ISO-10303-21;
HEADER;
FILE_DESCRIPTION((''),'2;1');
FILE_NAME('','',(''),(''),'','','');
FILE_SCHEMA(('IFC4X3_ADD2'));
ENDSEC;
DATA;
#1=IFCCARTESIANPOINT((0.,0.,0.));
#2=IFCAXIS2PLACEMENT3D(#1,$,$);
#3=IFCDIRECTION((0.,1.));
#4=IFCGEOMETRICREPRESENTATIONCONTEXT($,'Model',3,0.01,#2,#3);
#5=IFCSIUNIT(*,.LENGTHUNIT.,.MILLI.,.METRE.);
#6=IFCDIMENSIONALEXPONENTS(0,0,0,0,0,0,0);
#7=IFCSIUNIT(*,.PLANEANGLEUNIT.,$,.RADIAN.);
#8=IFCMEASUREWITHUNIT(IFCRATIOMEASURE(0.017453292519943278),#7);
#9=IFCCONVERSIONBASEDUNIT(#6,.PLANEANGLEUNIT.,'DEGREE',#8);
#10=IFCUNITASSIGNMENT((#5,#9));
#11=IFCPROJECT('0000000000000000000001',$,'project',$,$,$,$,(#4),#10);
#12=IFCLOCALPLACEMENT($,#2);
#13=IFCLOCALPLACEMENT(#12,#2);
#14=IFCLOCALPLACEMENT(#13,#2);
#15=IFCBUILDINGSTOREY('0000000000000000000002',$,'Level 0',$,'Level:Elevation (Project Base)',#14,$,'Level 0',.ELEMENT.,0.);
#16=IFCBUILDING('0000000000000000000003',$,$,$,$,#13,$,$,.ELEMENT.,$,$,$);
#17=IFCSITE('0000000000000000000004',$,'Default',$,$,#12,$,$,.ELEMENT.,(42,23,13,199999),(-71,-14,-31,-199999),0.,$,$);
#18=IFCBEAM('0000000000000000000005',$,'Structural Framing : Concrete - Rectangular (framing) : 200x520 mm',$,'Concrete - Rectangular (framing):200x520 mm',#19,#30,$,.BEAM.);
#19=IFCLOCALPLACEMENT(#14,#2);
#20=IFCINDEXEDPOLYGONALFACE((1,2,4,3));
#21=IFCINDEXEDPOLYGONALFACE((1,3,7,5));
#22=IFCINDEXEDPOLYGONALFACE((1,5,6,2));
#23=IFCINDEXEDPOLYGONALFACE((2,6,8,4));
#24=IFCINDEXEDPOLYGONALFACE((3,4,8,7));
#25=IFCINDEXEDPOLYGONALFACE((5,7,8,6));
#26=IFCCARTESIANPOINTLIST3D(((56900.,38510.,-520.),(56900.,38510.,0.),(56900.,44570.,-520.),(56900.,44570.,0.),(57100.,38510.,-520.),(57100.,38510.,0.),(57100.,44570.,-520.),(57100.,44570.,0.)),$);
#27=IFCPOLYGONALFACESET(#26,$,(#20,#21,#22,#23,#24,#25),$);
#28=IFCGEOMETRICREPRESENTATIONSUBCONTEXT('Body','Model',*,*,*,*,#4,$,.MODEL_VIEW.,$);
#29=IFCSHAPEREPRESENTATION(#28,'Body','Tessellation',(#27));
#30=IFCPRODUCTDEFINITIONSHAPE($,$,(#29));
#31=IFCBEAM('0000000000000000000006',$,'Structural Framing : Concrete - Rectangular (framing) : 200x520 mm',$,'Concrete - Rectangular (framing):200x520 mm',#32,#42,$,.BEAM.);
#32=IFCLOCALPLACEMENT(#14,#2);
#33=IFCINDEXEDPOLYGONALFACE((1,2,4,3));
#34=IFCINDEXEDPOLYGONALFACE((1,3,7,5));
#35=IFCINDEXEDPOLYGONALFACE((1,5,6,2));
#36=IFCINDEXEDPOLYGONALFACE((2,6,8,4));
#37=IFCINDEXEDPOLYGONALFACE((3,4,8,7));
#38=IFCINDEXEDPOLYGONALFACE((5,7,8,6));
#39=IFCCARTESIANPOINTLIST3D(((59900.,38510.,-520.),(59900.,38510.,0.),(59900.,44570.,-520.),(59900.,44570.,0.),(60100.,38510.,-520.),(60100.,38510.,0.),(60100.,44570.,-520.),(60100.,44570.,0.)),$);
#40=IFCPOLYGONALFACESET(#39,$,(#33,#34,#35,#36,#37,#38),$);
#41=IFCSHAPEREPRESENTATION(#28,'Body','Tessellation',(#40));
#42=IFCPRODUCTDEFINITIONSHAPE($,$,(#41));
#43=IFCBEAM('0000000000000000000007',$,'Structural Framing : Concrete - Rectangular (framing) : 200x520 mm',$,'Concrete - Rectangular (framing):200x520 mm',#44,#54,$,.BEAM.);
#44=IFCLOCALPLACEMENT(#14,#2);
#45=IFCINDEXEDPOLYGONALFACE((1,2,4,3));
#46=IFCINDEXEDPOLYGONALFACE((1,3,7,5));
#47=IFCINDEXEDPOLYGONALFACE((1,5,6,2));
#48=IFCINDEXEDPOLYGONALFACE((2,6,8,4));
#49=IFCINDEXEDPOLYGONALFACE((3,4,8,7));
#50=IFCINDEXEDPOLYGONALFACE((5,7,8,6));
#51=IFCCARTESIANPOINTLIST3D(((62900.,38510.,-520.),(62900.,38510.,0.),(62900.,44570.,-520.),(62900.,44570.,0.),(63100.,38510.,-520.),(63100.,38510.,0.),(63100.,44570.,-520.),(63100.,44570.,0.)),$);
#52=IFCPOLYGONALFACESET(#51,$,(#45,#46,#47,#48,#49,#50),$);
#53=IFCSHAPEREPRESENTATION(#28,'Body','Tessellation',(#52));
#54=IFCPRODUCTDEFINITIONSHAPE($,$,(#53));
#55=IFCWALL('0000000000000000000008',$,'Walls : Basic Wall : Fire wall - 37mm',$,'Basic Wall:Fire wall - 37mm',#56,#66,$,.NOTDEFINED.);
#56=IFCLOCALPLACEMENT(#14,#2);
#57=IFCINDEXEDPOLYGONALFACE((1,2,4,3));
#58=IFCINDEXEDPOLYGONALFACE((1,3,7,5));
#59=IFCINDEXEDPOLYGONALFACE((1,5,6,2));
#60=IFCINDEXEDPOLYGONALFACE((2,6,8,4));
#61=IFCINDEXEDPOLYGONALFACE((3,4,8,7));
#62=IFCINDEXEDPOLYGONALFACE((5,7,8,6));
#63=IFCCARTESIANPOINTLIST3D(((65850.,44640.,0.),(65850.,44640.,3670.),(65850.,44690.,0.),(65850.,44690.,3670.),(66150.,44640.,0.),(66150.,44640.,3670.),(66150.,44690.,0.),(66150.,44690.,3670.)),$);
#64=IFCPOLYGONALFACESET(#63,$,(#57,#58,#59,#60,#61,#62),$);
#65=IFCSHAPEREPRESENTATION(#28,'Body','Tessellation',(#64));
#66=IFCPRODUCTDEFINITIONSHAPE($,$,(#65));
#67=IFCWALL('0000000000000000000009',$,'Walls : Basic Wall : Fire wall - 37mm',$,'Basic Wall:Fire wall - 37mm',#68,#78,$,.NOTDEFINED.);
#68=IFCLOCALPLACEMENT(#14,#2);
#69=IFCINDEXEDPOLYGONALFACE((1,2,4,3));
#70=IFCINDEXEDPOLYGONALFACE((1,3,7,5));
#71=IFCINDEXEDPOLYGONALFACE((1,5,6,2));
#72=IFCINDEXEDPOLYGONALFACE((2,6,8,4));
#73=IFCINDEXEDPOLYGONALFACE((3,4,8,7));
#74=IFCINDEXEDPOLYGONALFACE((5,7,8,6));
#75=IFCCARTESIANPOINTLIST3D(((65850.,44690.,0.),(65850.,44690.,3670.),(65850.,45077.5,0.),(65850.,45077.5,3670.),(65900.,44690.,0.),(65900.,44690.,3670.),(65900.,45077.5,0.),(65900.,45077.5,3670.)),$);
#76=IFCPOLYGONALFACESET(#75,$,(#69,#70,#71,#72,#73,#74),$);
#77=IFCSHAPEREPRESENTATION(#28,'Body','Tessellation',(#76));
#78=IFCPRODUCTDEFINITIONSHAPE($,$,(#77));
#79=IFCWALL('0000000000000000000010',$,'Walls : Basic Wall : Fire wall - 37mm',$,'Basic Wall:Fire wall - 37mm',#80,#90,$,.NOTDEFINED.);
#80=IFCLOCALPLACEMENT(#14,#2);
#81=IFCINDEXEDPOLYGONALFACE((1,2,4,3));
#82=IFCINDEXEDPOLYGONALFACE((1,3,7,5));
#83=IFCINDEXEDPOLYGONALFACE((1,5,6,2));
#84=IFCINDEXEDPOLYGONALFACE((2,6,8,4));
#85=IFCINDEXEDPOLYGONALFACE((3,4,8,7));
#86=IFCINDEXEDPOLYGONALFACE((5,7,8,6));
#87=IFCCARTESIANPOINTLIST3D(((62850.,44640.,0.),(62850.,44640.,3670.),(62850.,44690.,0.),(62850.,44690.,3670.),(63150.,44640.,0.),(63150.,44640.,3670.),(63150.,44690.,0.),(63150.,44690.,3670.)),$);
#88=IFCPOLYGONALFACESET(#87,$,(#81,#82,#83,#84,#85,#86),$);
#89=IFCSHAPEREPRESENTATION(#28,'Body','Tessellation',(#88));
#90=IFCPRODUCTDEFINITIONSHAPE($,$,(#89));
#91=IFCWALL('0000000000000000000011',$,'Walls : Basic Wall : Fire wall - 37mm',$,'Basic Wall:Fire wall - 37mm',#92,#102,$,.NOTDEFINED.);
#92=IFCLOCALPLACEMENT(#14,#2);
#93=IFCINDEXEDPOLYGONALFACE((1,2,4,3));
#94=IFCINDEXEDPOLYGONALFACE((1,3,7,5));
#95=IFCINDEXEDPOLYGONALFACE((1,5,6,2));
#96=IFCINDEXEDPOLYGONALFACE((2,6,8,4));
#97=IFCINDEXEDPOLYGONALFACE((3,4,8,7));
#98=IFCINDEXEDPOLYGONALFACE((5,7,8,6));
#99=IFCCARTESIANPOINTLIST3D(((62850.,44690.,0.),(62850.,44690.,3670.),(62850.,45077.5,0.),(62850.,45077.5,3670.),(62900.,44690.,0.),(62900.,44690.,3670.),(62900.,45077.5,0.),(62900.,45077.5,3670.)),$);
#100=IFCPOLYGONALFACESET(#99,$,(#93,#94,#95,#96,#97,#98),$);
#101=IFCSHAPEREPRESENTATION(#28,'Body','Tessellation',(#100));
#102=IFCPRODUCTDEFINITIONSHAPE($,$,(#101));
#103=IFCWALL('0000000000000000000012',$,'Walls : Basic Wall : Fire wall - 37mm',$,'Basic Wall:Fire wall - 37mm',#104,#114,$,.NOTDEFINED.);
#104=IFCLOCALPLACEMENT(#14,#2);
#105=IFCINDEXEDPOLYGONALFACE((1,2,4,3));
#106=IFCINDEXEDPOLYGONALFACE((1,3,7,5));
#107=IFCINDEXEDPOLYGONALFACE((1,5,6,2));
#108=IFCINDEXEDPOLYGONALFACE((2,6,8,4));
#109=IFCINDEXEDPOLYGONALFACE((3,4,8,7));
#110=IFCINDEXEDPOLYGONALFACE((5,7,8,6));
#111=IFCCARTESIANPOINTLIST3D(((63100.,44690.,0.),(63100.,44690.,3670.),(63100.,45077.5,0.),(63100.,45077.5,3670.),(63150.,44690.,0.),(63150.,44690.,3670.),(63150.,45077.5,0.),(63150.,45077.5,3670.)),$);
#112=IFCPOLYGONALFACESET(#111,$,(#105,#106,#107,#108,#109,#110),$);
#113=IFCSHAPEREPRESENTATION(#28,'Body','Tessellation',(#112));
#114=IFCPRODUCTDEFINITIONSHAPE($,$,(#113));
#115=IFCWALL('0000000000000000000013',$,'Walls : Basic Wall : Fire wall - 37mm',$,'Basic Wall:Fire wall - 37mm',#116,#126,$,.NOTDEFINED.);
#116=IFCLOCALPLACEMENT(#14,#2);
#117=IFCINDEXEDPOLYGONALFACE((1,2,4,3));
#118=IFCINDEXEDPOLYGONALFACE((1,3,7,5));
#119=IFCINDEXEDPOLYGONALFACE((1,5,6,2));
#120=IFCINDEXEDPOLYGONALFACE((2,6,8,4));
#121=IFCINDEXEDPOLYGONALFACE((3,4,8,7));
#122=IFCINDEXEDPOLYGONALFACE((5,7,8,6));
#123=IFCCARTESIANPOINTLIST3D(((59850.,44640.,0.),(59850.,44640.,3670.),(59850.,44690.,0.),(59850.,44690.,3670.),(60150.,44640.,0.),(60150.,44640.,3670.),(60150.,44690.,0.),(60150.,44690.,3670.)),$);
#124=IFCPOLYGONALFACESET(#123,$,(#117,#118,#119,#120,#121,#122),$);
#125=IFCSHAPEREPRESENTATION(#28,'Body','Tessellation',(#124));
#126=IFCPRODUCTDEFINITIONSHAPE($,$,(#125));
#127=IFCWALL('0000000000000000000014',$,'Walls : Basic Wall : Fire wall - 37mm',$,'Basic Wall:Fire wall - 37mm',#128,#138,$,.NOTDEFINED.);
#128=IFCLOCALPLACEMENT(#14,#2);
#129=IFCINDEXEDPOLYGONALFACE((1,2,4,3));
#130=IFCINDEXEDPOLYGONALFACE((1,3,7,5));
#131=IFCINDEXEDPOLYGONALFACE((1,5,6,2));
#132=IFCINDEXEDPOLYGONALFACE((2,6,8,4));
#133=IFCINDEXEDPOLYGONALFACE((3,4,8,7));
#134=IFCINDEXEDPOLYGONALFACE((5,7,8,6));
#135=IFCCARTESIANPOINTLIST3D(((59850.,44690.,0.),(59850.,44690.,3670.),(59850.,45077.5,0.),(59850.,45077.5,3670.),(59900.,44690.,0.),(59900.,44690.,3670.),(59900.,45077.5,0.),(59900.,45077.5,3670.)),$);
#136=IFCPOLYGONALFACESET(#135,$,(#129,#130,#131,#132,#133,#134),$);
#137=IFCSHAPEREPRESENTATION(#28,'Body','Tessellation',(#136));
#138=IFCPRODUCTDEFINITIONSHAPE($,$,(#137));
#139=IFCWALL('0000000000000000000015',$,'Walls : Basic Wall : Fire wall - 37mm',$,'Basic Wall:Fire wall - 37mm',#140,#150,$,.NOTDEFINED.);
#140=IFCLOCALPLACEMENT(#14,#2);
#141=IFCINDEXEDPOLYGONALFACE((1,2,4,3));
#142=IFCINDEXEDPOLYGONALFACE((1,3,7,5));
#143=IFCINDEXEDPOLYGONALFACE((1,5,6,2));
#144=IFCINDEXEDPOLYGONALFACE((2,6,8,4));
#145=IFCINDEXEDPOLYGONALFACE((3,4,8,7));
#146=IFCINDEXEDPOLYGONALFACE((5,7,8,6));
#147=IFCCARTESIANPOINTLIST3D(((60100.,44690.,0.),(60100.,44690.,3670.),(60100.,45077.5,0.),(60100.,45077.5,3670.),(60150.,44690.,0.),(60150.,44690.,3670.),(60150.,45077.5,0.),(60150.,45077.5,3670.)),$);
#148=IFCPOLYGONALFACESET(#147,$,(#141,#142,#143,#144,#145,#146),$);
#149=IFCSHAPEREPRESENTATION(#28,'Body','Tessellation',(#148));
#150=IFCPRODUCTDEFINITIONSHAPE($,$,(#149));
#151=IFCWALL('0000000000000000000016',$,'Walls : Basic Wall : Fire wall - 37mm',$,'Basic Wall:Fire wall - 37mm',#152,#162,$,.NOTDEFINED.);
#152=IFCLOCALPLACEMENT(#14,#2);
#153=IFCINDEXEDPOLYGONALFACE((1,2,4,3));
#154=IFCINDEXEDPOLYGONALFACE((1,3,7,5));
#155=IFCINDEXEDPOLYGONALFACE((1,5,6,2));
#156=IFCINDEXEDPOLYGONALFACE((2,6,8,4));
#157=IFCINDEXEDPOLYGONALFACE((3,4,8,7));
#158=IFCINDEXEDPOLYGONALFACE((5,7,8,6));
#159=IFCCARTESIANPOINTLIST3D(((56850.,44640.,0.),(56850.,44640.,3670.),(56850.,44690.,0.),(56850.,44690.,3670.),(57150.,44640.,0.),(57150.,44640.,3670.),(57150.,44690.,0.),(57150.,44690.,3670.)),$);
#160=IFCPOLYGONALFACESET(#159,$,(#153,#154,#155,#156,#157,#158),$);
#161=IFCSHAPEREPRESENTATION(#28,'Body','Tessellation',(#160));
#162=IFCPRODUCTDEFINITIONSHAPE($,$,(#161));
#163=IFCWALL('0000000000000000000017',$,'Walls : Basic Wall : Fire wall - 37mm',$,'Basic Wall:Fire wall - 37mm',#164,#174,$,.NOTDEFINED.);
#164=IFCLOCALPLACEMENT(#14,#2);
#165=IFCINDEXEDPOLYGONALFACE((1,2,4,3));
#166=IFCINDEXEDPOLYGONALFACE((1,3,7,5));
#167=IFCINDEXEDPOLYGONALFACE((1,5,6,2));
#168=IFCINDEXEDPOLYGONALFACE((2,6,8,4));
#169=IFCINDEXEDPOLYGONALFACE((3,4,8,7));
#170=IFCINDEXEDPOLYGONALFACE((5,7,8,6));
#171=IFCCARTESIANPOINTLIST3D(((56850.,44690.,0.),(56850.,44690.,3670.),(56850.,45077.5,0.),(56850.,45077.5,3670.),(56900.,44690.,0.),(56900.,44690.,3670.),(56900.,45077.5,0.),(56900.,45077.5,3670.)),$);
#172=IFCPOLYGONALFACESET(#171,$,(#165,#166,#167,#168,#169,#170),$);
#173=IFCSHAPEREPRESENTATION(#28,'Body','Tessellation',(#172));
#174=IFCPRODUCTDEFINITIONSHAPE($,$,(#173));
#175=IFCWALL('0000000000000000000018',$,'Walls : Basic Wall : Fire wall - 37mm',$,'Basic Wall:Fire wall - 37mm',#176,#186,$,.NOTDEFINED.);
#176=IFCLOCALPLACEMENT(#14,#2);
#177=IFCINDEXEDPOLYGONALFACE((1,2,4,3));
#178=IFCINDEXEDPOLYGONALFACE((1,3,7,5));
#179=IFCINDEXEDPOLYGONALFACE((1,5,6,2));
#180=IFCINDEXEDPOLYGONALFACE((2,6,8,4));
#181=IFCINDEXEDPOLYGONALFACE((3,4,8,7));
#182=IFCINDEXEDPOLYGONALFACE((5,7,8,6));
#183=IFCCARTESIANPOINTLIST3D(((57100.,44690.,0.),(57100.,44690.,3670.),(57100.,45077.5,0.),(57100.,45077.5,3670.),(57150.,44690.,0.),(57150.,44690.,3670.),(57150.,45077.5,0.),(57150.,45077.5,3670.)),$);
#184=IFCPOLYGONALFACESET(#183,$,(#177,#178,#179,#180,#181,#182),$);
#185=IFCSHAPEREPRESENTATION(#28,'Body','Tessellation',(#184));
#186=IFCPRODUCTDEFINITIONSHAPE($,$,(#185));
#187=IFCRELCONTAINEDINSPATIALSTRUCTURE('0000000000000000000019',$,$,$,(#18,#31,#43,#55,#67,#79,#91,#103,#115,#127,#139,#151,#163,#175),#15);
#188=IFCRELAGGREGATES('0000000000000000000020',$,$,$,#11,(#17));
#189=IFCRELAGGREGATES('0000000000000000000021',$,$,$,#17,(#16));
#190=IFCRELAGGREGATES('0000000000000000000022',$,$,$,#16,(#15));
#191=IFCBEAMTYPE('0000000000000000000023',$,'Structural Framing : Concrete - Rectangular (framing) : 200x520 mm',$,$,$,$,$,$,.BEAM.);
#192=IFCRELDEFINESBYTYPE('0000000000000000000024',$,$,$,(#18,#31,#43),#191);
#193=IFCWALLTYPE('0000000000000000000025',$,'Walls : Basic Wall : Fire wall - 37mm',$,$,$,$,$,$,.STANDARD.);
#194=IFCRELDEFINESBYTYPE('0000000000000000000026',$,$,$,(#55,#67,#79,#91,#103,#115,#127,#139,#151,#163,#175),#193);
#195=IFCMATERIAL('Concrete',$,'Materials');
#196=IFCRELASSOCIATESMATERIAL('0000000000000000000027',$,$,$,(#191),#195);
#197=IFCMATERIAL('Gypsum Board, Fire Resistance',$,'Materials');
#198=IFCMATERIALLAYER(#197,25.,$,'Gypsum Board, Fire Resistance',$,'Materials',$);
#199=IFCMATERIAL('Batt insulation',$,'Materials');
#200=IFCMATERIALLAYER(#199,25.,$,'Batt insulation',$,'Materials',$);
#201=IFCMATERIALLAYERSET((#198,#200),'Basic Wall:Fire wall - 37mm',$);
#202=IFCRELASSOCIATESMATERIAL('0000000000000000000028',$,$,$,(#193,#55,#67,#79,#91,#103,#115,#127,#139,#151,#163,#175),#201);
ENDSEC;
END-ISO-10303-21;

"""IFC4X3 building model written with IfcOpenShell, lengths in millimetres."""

from ifc_helpers import new_model, entity, si_unit, converted_unit, direction, frame, frame_2d, origin, place, context, subcontext, project, spatial, rectangle, extrude, source, transform, mapped, material, layer, layer_set, material_profile, profile_set, type_object, type_shapes, element, save


model = new_model("IFC4X3")

# Units and contexts
model_context = context("Model", 3, precision=0.01, world=origin(), true_north=direction((0.0, 1.0)))
body_context = subcontext(model_context, "Body", "Model", "MODEL_VIEW")
ifc_project = project(units=[si_unit("LENGTHUNIT", "METRE", prefix="MILLI"), converted_unit("PLANEANGLEUNIT", "DEGREE", entity("IfcRatioMeasure", 0.017453292519943278), si_unit("PLANEANGLEUNIT", "RADIAN"), dimensions=[0, 0, 0, 0, 0, 0, 0])], contexts=[model_context])

# Site, building, storey
site_placement = place(None, origin())
site = spatial("IfcSite", under=ifc_project, at=site_placement, Name="Default", CompositionType="ELEMENT", RefLatitude=(42, 23, 13, 199999), RefLongitude=(-71, -14, -31, -199999), RefElevation=0.0)
building_placement = place(site_placement, origin())
building = spatial("IfcBuilding", under=site, at=building_placement, CompositionType="ELEMENT")
storey_placement = place(building_placement, origin())
storey = spatial("IfcBuildingStorey", under=building, at=storey_placement, Name="Level 0", ObjectType="Level:Elevation (Project Base)", LongName="Level 0", CompositionType="ELEMENT", Elevation=0.0)

# Beams
ifc_material_1 = material(Name="Concrete", Category="Materials")
ifc_material_profile = material_profile(ifc_material_1, rectangle(XDim=520.0, YDim=200.0, at=frame_2d((0.0, 0.0), x_axis=(1.0, 0.0))), Name="200x520 mm")
ifc_profile_set = profile_set([ifc_material_profile], Name="200x520 mm")
beam_type = type_object("IfcBeamType", Name="Structural Framing : Concrete - Rectangular (framing) : 200x520 mm", PredefinedType="BEAM", material=ifc_profile_set)
shared_shape = source(origin(), body_context, "Body", "SweptSolid", [
    extrude(rectangle(XDim=520.0, YDim=200.0, at=frame_2d((0.0, 0.0), x_axis=(1.0, 0.0))), frame((-1230.0, 0.0, 0.0), z_axis=(1.0, 0.0, 0.0), x_axis=(0.0, 0.0, -1.0)), (0.0, 0.0, 1.0), 6060.0),
])
type_shapes(beam_type, [shared_shape])
for number, where, z_axis, x_axis, name in (
    (1, (57000.0, 43340.0, -260.0), (0.0, 0.0, 1.0), (0.0, -1.0, 0.0), "Structural Framing : Concrete - Rectangular (framing) : 200x520 mm"),
    (2, (60000.0, 43340.0, -260.0), (0.0, 0.0, 1.0), (0.0, -1.0, 0.0), "Structural Framing : Concrete - Rectangular (framing) : 200x520 mm"),
    (3, (63000.0, 43340.0, -260.0), (0.0, 0.0, 1.0), (0.0, -1.0, 0.0), "Structural Framing : Concrete - Rectangular (framing) : 200x520 mm"),
):
    element("IfcBeam", number, at=place(storey_placement, frame(where, z_axis=z_axis, x_axis=x_axis)), inside=storey, type_object=beam_type, Name=name, ObjectType="Concrete - Rectangular (framing):200x520 mm", PredefinedType="BEAM", context=body_context, shape_type="MappedRepresentation", body=[
        mapped(shared_shape, transform((0.0, 0.0, 0.0), scale=1.0)),
    ])

# Walls
ifc_material_2 = material(Name="Gypsum Board, Fire Resistance", Category="Materials")
ifc_layer_1 = layer(ifc_material_2, 25.0, Name="Gypsum Board, Fire Resistance", Category="Materials")
ifc_material_3 = material(Name="Batt insulation", Category="Materials")
ifc_layer_2 = layer(ifc_material_3, 25.0, Name="Batt insulation", Category="Materials")
ifc_layer_set = layer_set([ifc_layer_1, ifc_layer_2], Name="Basic Wall:Fire wall - 37mm")
wall_type = type_object("IfcWallType", Name="Walls : Basic Wall : Fire wall - 37mm", PredefinedType="STANDARD", material=ifc_layer_set)
wall_1_placement = place(storey_placement, frame((65850.0, 44665.0, 0.0)))
element("IfcWall", 4, at=wall_1_placement, inside=storey, type_object=wall_type, material=ifc_layer_set, Name="Walls : Basic Wall : Fire wall - 37mm", ObjectType="Basic Wall:Fire wall - 37mm", PredefinedType="NOTDEFINED", context=body_context, shape_type="SweptSolid", body=[
    extrude(rectangle(XDim=300.0, YDim=50.0, at=frame_2d((150.0, 0.0), x_axis=(-1.0, 0.0))), origin(), (0.0, 0.0, 1.0), 3670.0),
])
wall_2_placement = place(storey_placement, frame((65875.0, 45077.5, 0.0), z_axis=(0.0, 0.0, 1.0), x_axis=(0.0, -1.0, 0.0)))
element("IfcWall", 5, at=wall_2_placement, inside=storey, type_object=wall_type, material=ifc_layer_set, Name="Walls : Basic Wall : Fire wall - 37mm", ObjectType="Basic Wall:Fire wall - 37mm", PredefinedType="NOTDEFINED", context=body_context, shape_type="SweptSolid", body=[
    extrude(rectangle(XDim=387.5, YDim=50.0, at=frame_2d((193.7, 0.0), x_axis=(-1.0, 0.0))), origin(), (0.0, 0.0, 1.0), 3670.0),
])
wall_3_placement = place(storey_placement, frame((62850.0, 44665.0, 0.0)))
element("IfcWall", 6, at=wall_3_placement, inside=storey, type_object=wall_type, material=ifc_layer_set, Name="Walls : Basic Wall : Fire wall - 37mm", ObjectType="Basic Wall:Fire wall - 37mm", PredefinedType="NOTDEFINED", context=body_context, shape_type="SweptSolid", body=[
    extrude(rectangle(XDim=300.0, YDim=50.0, at=frame_2d((150.0, 0.0), x_axis=(-1.0, 0.0))), origin(), (0.0, 0.0, 1.0), 3670.0),
])
wall_4_placement = place(storey_placement, frame((62875.0, 45077.5, 0.0), z_axis=(0.0, 0.0, 1.0), x_axis=(0.0, -1.0, 0.0)))
element("IfcWall", 7, at=wall_4_placement, inside=storey, type_object=wall_type, material=ifc_layer_set, Name="Walls : Basic Wall : Fire wall - 37mm", ObjectType="Basic Wall:Fire wall - 37mm", PredefinedType="NOTDEFINED", context=body_context, shape_type="SweptSolid", body=[
    extrude(rectangle(XDim=387.5, YDim=50.0, at=frame_2d((193.7, 0.0), x_axis=(-1.0, 0.0))), origin(), (0.0, 0.0, 1.0), 3670.0),
])
wall_5_placement = place(storey_placement, frame((63125.0, 45077.5, 0.0), z_axis=(0.0, 0.0, 1.0), x_axis=(0.0, -1.0, 0.0)))
element("IfcWall", 8, at=wall_5_placement, inside=storey, type_object=wall_type, material=ifc_layer_set, Name="Walls : Basic Wall : Fire wall - 37mm", ObjectType="Basic Wall:Fire wall - 37mm", PredefinedType="NOTDEFINED", context=body_context, shape_type="SweptSolid", body=[
    extrude(rectangle(XDim=387.5, YDim=50.0, at=frame_2d((193.7, 0.0), x_axis=(-1.0, 0.0))), origin(), (0.0, 0.0, 1.0), 3670.0),
])
wall_6_placement = place(storey_placement, frame((59850.0, 44665.0, 0.0)))
element("IfcWall", 9, at=wall_6_placement, inside=storey, type_object=wall_type, material=ifc_layer_set, Name="Walls : Basic Wall : Fire wall - 37mm", ObjectType="Basic Wall:Fire wall - 37mm", PredefinedType="NOTDEFINED", context=body_context, shape_type="SweptSolid", body=[
    extrude(rectangle(XDim=300.0, YDim=50.0, at=frame_2d((150.0, 0.0), x_axis=(-1.0, 0.0))), origin(), (0.0, 0.0, 1.0), 3670.0),
])
wall_7_placement = place(storey_placement, frame((59875.0, 45077.5, 0.0), z_axis=(0.0, 0.0, 1.0), x_axis=(0.0, -1.0, 0.0)))
element("IfcWall", 10, at=wall_7_placement, inside=storey, type_object=wall_type, material=ifc_layer_set, Name="Walls : Basic Wall : Fire wall - 37mm", ObjectType="Basic Wall:Fire wall - 37mm", PredefinedType="NOTDEFINED", context=body_context, shape_type="SweptSolid", body=[
    extrude(rectangle(XDim=387.5, YDim=50.0, at=frame_2d((193.7, 0.0), x_axis=(-1.0, 0.0))), origin(), (0.0, 0.0, 1.0), 3670.0),
])
wall_8_placement = place(storey_placement, frame((60125.0, 45077.5, 0.0), z_axis=(0.0, 0.0, 1.0), x_axis=(0.0, -1.0, 0.0)))
element("IfcWall", 11, at=wall_8_placement, inside=storey, type_object=wall_type, material=ifc_layer_set, Name="Walls : Basic Wall : Fire wall - 37mm", ObjectType="Basic Wall:Fire wall - 37mm", PredefinedType="NOTDEFINED", context=body_context, shape_type="SweptSolid", body=[
    extrude(rectangle(XDim=387.5, YDim=50.0, at=frame_2d((193.7, 0.0), x_axis=(-1.0, 0.0))), origin(), (0.0, 0.0, 1.0), 3670.0),
])
wall_9_placement = place(storey_placement, frame((56850.0, 44665.0, 0.0)))
element("IfcWall", 12, at=wall_9_placement, inside=storey, type_object=wall_type, material=ifc_layer_set, Name="Walls : Basic Wall : Fire wall - 37mm", ObjectType="Basic Wall:Fire wall - 37mm", PredefinedType="NOTDEFINED", context=body_context, shape_type="SweptSolid", body=[
    extrude(rectangle(XDim=300.0, YDim=50.0, at=frame_2d((150.0, 0.0), x_axis=(-1.0, 0.0))), origin(), (0.0, 0.0, 1.0), 3670.0),
])
for number, where, z_axis, x_axis, name in (
    (13, (56875.0, 45077.5, 0.0), (0.0, 0.0, 1.0), (0.0, -1.0, 0.0), "Walls : Basic Wall : Fire wall - 37mm"),
    (14, (57125.0, 45077.5, 0.0), (0.0, 0.0, 1.0), (0.0, -1.0, 0.0), "Walls : Basic Wall : Fire wall - 37mm"),
):
    element("IfcWall", number, at=place(storey_placement, frame(where, z_axis=z_axis, x_axis=x_axis)), inside=storey, type_object=wall_type, material=ifc_layer_set, Name=name, ObjectType="Basic Wall:Fire wall - 37mm", PredefinedType="NOTDEFINED", context=body_context, shape_type="SweptSolid", body=[
        extrude(rectangle(XDim=387.5, YDim=50.0, at=frame_2d((193.7, 0.0), x_axis=(-1.0, 0.0))), origin(), (0.0, 0.0, 1.0), 3670.0),
    ])

save(model, "model.ifc")
